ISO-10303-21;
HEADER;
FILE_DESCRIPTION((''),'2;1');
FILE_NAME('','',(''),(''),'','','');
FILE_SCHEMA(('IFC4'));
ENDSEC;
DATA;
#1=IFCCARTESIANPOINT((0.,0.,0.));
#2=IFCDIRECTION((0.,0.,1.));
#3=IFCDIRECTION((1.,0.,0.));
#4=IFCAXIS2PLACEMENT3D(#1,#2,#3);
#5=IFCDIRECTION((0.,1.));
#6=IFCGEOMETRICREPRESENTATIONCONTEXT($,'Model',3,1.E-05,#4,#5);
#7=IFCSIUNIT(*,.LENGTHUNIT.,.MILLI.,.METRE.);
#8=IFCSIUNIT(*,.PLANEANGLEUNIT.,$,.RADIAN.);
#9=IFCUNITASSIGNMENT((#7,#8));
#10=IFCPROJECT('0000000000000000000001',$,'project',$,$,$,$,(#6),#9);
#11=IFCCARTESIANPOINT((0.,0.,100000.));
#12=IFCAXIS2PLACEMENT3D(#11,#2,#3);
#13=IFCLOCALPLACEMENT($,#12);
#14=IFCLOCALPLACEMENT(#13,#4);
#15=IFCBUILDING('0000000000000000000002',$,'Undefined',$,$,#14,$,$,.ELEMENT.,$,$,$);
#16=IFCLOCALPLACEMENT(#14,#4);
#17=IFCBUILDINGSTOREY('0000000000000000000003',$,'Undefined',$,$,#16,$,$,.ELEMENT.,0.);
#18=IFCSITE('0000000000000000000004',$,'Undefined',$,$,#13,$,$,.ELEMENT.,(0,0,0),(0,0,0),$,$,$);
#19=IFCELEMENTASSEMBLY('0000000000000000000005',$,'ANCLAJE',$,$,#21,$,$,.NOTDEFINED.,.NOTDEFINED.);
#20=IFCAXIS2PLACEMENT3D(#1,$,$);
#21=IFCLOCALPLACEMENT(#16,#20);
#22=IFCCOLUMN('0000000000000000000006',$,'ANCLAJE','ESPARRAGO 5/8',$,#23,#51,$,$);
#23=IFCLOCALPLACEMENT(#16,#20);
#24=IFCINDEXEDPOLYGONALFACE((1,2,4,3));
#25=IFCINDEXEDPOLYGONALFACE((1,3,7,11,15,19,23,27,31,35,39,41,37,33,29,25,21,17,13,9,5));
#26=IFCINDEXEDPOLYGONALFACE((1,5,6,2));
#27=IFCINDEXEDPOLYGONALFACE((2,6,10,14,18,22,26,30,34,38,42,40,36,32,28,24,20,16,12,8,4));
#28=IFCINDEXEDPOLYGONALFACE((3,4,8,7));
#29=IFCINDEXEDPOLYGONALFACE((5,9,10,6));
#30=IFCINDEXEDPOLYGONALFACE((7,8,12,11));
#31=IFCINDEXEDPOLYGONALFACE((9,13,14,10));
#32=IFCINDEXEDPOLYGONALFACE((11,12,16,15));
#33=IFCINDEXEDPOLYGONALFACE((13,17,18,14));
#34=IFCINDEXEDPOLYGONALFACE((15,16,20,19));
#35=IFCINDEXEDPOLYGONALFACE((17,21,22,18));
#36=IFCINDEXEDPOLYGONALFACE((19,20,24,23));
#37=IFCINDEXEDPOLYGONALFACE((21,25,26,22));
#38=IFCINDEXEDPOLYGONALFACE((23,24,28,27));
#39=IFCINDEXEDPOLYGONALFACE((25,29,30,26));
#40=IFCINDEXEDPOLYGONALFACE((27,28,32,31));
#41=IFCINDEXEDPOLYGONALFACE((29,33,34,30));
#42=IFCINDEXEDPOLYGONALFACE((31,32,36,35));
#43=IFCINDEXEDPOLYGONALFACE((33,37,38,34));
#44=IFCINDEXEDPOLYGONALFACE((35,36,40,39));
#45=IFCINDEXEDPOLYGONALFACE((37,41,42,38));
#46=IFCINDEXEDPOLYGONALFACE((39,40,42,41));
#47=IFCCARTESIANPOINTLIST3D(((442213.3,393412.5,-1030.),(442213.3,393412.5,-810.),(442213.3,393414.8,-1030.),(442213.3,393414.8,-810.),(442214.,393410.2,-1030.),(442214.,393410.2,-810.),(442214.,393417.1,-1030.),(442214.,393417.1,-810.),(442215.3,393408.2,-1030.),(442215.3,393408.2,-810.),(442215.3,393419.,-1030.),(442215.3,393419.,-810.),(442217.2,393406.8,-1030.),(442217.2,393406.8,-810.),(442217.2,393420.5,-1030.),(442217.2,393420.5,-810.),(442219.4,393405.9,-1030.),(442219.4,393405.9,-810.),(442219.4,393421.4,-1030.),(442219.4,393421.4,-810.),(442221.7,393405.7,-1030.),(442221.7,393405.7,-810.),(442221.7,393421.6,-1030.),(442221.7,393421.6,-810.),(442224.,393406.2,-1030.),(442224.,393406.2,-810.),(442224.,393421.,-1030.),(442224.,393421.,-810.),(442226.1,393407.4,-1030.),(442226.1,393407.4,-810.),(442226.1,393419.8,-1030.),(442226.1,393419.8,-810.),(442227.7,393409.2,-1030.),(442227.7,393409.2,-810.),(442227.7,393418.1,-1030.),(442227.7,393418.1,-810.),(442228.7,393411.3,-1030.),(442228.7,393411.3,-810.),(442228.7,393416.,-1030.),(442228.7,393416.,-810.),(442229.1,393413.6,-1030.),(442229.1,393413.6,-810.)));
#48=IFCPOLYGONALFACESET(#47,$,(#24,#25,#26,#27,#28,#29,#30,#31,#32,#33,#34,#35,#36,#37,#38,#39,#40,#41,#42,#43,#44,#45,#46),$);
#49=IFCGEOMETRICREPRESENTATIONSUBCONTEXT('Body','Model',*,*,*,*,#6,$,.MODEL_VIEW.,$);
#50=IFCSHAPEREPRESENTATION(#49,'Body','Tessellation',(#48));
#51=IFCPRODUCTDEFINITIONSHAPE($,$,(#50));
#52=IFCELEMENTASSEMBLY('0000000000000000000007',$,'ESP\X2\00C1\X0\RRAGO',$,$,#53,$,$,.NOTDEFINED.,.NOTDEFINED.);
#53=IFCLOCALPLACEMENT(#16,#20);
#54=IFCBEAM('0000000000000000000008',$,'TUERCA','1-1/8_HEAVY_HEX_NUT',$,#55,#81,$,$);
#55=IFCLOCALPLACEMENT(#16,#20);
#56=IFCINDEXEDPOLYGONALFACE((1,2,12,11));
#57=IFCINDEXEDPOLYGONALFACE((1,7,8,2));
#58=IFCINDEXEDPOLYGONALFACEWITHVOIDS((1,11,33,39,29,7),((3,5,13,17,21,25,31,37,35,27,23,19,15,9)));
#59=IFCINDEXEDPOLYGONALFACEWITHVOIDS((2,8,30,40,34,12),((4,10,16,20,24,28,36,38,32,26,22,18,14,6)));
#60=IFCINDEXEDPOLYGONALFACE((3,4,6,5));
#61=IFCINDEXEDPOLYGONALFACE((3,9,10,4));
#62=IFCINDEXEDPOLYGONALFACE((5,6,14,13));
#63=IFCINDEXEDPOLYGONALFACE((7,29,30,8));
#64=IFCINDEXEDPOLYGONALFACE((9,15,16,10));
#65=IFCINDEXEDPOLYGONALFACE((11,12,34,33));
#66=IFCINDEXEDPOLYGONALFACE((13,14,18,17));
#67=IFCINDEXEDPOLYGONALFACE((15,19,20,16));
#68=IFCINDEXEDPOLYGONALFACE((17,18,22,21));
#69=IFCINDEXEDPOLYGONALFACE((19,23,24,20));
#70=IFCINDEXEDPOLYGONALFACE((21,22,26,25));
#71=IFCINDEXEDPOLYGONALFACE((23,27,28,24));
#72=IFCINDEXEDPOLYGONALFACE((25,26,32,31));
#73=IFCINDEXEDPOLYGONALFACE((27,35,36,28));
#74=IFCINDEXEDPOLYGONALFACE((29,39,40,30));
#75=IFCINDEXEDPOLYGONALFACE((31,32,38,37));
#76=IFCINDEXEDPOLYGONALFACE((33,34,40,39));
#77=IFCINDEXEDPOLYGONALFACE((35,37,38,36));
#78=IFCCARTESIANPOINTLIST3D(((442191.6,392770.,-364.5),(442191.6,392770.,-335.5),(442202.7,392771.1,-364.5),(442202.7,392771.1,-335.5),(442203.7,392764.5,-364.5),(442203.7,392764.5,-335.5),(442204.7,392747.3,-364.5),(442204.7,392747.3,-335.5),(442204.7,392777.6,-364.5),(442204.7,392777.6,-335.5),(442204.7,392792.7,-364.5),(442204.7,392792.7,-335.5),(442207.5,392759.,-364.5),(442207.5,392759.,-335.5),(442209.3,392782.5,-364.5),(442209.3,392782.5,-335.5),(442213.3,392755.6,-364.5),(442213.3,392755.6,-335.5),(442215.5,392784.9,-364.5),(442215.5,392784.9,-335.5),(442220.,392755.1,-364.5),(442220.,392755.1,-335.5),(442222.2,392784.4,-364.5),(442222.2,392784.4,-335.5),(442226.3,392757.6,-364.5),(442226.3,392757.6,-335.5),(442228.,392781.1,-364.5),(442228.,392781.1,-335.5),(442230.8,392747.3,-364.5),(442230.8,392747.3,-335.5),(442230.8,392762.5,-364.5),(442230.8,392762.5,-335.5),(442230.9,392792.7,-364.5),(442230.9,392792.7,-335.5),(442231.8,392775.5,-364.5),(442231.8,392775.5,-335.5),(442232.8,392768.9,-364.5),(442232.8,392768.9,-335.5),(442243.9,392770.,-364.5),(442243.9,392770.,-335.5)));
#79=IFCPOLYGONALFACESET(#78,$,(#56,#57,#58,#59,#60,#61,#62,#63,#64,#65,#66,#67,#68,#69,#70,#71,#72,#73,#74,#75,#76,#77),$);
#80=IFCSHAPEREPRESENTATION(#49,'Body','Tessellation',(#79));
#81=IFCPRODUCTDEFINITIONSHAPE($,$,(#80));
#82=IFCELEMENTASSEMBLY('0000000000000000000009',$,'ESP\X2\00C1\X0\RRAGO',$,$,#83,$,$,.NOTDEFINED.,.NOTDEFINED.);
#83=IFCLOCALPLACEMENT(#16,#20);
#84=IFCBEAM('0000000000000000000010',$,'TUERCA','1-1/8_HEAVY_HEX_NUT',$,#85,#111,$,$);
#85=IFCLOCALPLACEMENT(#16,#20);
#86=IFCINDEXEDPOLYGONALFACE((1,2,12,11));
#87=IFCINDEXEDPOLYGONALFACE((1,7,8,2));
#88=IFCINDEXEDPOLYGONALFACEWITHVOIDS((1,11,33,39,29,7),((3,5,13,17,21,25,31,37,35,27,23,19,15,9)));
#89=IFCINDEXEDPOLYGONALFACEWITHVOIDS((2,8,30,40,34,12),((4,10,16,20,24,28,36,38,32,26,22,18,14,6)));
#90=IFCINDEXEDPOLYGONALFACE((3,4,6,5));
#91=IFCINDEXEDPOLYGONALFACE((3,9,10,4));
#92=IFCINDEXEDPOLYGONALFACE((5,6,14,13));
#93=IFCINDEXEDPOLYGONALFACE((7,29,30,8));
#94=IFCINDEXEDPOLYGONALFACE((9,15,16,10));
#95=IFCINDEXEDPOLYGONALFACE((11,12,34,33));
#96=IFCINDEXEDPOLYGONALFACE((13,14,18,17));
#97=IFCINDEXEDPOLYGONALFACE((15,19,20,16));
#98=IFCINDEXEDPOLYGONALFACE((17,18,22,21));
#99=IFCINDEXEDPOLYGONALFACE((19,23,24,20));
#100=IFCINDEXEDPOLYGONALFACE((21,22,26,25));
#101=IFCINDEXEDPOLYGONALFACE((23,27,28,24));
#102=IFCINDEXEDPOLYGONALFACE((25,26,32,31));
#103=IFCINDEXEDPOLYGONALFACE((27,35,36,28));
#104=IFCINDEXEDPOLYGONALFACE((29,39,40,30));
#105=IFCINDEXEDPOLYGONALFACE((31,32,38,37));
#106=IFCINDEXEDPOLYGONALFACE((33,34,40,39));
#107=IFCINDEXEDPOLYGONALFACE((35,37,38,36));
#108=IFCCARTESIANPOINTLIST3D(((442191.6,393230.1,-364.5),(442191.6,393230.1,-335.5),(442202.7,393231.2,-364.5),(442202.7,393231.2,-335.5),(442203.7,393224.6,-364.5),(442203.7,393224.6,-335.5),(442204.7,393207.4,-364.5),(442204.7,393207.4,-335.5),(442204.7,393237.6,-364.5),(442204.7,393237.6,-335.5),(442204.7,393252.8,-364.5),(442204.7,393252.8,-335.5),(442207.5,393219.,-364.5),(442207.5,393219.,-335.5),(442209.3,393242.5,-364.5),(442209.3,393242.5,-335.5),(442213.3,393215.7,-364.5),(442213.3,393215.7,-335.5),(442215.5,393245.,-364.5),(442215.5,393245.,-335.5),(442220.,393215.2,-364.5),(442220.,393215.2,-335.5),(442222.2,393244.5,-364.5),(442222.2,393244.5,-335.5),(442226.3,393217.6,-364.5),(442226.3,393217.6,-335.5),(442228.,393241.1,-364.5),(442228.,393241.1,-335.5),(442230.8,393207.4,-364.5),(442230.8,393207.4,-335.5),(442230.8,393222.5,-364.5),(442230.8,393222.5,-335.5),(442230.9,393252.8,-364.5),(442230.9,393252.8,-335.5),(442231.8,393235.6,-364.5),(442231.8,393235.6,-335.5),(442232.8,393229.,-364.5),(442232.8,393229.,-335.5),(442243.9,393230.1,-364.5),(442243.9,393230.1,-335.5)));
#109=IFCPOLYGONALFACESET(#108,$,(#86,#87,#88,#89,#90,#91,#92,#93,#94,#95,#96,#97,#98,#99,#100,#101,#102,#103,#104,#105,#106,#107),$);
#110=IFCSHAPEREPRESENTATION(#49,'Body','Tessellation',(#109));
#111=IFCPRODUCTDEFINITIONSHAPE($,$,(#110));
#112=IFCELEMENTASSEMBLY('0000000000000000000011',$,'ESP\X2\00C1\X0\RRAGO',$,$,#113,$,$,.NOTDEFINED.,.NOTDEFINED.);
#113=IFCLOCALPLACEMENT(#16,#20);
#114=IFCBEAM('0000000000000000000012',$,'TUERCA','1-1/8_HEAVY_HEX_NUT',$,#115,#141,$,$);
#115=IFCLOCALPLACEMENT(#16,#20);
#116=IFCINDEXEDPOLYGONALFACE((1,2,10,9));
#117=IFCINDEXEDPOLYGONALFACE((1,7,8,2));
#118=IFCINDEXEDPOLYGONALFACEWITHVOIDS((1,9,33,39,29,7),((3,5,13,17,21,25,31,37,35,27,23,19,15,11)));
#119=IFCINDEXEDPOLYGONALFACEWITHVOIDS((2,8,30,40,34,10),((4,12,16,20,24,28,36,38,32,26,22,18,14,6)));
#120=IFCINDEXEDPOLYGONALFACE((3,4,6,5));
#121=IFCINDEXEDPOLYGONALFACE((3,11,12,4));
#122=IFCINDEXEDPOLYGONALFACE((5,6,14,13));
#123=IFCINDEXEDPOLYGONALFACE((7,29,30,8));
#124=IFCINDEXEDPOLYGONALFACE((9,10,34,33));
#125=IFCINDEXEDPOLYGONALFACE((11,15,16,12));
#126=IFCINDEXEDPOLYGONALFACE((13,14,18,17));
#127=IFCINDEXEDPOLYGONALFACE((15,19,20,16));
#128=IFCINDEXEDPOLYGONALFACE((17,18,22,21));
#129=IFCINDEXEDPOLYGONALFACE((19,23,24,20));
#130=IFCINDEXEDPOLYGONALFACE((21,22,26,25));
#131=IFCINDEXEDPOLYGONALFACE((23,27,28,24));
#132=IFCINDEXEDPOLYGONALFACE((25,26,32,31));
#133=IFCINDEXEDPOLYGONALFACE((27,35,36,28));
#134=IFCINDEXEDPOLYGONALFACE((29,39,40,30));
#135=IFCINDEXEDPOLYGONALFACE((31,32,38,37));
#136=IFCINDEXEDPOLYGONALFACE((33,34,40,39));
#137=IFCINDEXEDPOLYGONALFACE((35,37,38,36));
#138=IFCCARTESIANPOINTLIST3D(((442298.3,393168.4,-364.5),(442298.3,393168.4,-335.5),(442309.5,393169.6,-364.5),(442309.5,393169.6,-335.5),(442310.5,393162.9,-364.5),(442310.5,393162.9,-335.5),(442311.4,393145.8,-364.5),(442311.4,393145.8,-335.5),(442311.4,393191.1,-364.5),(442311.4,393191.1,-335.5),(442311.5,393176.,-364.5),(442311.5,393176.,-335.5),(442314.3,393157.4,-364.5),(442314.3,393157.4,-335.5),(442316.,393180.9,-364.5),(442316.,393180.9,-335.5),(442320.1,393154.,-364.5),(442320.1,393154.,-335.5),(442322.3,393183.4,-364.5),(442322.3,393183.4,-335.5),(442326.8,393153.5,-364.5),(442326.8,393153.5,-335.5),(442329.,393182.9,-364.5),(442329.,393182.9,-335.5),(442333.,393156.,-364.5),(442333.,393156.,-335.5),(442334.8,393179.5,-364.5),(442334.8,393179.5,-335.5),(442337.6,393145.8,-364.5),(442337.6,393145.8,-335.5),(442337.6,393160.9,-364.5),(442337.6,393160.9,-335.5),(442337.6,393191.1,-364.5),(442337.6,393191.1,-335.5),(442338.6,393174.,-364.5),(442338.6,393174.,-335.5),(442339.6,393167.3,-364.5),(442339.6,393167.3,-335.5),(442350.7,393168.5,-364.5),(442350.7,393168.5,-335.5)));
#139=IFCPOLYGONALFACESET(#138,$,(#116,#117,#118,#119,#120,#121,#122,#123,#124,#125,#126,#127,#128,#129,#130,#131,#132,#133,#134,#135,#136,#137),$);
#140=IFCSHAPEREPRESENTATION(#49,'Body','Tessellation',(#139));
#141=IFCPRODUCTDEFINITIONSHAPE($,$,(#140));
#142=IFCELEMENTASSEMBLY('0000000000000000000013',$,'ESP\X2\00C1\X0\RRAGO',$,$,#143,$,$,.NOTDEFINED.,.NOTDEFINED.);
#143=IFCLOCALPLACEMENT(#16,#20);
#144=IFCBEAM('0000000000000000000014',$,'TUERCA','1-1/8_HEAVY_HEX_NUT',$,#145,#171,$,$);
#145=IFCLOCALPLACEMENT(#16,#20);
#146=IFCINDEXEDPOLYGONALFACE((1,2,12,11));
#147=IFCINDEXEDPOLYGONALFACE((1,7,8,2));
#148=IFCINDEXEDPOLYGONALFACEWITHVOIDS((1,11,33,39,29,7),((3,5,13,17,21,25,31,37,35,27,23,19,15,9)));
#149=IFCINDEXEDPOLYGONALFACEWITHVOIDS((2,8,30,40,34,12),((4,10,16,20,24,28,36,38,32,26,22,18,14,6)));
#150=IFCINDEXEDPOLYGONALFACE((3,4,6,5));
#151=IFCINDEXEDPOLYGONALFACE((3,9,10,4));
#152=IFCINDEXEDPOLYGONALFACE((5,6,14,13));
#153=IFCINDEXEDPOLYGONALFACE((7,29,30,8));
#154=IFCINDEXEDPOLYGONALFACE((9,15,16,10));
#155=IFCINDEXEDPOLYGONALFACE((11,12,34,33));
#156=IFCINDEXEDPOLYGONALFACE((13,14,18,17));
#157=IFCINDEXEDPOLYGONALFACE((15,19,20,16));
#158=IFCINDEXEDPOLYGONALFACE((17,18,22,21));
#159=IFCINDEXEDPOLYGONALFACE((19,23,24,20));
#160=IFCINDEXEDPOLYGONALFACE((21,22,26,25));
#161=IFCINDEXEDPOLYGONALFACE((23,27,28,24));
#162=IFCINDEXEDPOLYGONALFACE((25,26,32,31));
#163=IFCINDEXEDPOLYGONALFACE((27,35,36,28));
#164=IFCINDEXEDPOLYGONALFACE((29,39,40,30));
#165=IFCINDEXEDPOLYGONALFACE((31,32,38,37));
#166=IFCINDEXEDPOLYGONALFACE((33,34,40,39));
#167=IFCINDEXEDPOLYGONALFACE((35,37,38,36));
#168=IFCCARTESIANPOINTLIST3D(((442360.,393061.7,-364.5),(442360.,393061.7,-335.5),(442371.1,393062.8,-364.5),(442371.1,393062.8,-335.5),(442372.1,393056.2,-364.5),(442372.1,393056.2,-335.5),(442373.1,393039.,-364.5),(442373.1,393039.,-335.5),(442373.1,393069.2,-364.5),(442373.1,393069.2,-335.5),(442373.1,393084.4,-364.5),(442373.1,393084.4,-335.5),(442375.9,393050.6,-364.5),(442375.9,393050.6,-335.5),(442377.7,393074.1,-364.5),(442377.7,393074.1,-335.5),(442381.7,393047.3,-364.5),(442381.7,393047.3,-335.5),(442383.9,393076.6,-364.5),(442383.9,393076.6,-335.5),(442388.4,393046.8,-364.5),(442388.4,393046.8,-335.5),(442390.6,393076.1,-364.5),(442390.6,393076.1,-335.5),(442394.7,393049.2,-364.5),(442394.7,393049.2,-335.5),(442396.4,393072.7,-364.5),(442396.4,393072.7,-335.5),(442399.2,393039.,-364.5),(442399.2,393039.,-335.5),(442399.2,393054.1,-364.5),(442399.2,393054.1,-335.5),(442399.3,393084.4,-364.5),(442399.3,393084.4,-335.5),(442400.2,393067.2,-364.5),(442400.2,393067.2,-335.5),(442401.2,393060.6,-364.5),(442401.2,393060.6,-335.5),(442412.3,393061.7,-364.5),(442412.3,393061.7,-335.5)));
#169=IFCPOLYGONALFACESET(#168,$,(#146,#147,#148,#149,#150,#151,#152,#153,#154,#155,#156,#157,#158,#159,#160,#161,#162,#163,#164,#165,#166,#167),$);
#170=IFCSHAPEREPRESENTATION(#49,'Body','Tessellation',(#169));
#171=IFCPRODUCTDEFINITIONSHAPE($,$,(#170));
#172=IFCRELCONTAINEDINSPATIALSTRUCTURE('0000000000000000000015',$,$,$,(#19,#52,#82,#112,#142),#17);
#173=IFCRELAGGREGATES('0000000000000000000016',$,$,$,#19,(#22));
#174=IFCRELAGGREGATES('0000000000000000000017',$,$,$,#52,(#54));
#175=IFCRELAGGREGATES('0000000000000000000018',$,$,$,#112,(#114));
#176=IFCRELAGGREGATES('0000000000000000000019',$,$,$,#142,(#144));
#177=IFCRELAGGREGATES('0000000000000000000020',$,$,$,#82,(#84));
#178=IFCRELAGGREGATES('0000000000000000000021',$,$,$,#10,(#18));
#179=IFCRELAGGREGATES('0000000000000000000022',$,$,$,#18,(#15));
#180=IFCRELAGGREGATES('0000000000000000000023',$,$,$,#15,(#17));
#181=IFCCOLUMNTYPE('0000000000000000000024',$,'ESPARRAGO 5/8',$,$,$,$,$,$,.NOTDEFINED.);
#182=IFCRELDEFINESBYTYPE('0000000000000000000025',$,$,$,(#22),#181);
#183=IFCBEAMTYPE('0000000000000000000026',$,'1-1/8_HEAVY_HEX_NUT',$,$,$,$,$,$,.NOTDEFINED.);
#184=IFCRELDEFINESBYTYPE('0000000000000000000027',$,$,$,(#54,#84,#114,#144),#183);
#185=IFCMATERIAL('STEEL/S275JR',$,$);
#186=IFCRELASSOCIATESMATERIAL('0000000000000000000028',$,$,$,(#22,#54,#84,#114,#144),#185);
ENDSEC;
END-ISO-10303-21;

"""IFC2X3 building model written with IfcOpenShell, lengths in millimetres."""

from ifc_helpers import new_model, si_unit, direction, frame, origin_with_axes, origin_2d_with_axis, place, context, subcontext, project, spatial, polyline, circle, outline, extrude, material, type_object, element, aggregate, save


model = new_model("IFC2X3")

# Units and contexts
model_context = context("Model", 3, precision=1e-05, world=origin_with_axes(), true_north=direction((0.0, 1.0)))
body_context = subcontext(model_context, "Body", "Model", "MODEL_VIEW")
ifc_project = project(units=[si_unit("LENGTHUNIT", "METRE", prefix="MILLI"), si_unit("PLANEANGLEUNIT", "RADIAN")], contexts=[model_context])

# Site, building, storey
site_placement = place(None, frame((0.0, 0.0, 100000.0), z_axis=(0.0, 0.0, 1.0), x_axis=(1.0, 0.0, 0.0)))
site = spatial("IfcSite", under=ifc_project, at=site_placement, Name="Undefined", CompositionType="ELEMENT", RefLatitude=(0, 0, 0), RefLongitude=(0, 0, 0))
building_placement = place(site_placement, origin_with_axes())
building = spatial("IfcBuilding", under=site, at=building_placement, Name="Undefined", CompositionType="ELEMENT")
storey_placement = place(building_placement, origin_with_axes())
storey = spatial("IfcBuildingStorey", under=building, at=storey_placement, Name="Undefined", CompositionType="ELEMENT", Elevation=0.0)

# Element assembly
ifc_material_1 = material(Name="STEEL/S275JR")
assembly_1_placement = place(storey_placement, origin_with_axes())
assembly_1 = element("IfcElementAssembly", 1, at=assembly_1_placement, inside=storey, Name="ANCLAJE", AssemblyPlace="NOTDEFINED", PredefinedType="NOTDEFINED")

# Column
column_type_1 = type_object("IfcColumnType", Name="ESPARRAGO 5/8", PredefinedType="NOTDEFINED")
column_1_placement = place(assembly_1_placement, frame((442221.1, 393413.6, -810.0), z_axis=(0.0, 0.0, -1.0), x_axis=(0.0, 1.0, 0.0)))
column_1 = element("IfcColumn", 2, at=column_1_placement, type_object=column_type_1, material=ifc_material_1, Name="ANCLAJE", Description="ESPARRAGO 5/8", context=body_context, shape_type="SweptSolid", body=[
    extrude(circle(Radius=7.9, at=origin_2d_with_axis()), frame((0.0, 0.0, 220.0), z_axis=(0.0, 0.0, -1.0), x_axis=(0.0, 1.0, 0.0)), (0.0, 0.0, 1.0), 220.0),
])
aggregate(assembly_1, [column_1])

# Element assemblies, beams
assembly_2_placement = place(storey_placement, origin_with_axes())
assembly_2 = element("IfcElementAssembly", 3, at=assembly_2_placement, inside=storey, Name="ESPÁRRAGO", AssemblyPlace="NOTDEFINED", PredefinedType="NOTDEFINED")
beam_type_1 = type_object("IfcBeamType", Name="1-1/8_HEAVY_HEX_NUT", PredefinedType="NOTDEFINED")
beam_1_placement = place(assembly_2_placement, frame((442217.8, 392770.0, -335.5), z_axis=(0.866025, -0.5, 0.0), x_axis=(0.0, 0.0, -1.0)))
beam_1 = element("IfcBeam", 4, at=beam_1_placement, type_object=beam_type_1, material=ifc_material_1, Name="TUERCA", Description="1-1/8_HEAVY_HEX_NUT", context=body_context, shape_type="SweptSolid", body=[
    extrude(outline(polyline([(-13.1, -22.7), (-26.2, 0.0), (-13.1, 22.7), (13.1, 22.7), (26.2, 0.0), (13.1, -22.7), (-13.1, -22.7)]), holes=[polyline([(6.5, 13.6), (0.0, 15.1), (-6.5, 13.6), (-11.8, 9.4), (-14.7, 3.4), (-14.7, -3.4), (-11.8, -9.4), (-6.5, -13.6), (0.0, -15.1), (6.5, -13.6), (11.8, -9.4), (14.7, -3.4), (14.7, 3.4), (11.8, 9.4), (6.5, 13.6)])]), frame((29.0, 0.0, 0.0), z_axis=(-1.0, 0.0, 0.0), x_axis=(0.0, -1.0, 0.0)), (0.0, 0.0, 1.0), 29.0),
])
assembly_3_placement = place(storey_placement, origin_with_axes())
assembly_3 = element("IfcElementAssembly", 5, at=assembly_3_placement, inside=storey, Name="ESPÁRRAGO", AssemblyPlace="NOTDEFINED", PredefinedType="NOTDEFINED")
beam_2_placement = place(assembly_3_placement, frame((442217.8, 393230.1, -335.5), z_axis=(0.866025, -0.5, 0.0), x_axis=(0.0, 0.0, -1.0)))
beam_2 = element("IfcBeam", 6, at=beam_2_placement, type_object=beam_type_1, material=ifc_material_1, Name="TUERCA", Description="1-1/8_HEAVY_HEX_NUT", context=body_context, shape_type="SweptSolid", body=[
    extrude(outline(polyline([(-13.1, -22.7), (-26.2, 0.0), (-13.1, 22.7), (13.1, 22.7), (26.2, 0.0), (13.1, -22.7), (-13.1, -22.7)]), holes=[polyline([(6.5, 13.6), (0.0, 15.1), (-6.5, 13.6), (-11.8, 9.4), (-14.7, 3.4), (-14.7, -3.4), (-11.8, -9.4), (-6.5, -13.6), (0.0, -15.1), (6.5, -13.6), (11.8, -9.4), (14.7, -3.4), (14.7, 3.4), (11.8, 9.4), (6.5, 13.6)])]), frame((29.0, 0.0, 0.0), z_axis=(-1.0, 0.0, 0.0), x_axis=(0.0, -1.0, 0.0)), (0.0, 0.0, 1.0), 29.0),
])
assembly_4_placement = place(storey_placement, origin_with_axes())
assembly_4 = element("IfcElementAssembly", 7, at=assembly_4_placement, inside=storey, Name="ESPÁRRAGO", AssemblyPlace="NOTDEFINED", PredefinedType="NOTDEFINED")
beam_3_placement = place(assembly_4_placement, frame((442324.5, 393168.4, -335.5), z_axis=(0.866025, -0.5, 0.0), x_axis=(0.0, 0.0, -1.0)))
beam_3 = element("IfcBeam", 8, at=beam_3_placement, type_object=beam_type_1, material=ifc_material_1, Name="TUERCA", Description="1-1/8_HEAVY_HEX_NUT", context=body_context, shape_type="SweptSolid", body=[
    extrude(outline(polyline([(-13.1, -22.7), (-26.2, 0.0), (-13.1, 22.7), (13.1, 22.7), (26.2, 0.0), (13.1, -22.7), (-13.1, -22.7)]), holes=[polyline([(6.5, 13.6), (0.0, 15.1), (-6.5, 13.6), (-11.8, 9.4), (-14.7, 3.4), (-14.7, -3.4), (-11.8, -9.4), (-6.5, -13.6), (0.0, -15.1), (6.5, -13.6), (11.8, -9.4), (14.7, -3.4), (14.7, 3.4), (11.8, 9.4), (6.5, 13.6)])]), frame((29.0, 0.0, 0.0), z_axis=(-1.0, 0.0, 0.0), x_axis=(0.0, -1.0, 0.0)), (0.0, 0.0, 1.0), 29.0),
])
assembly_5_placement = place(storey_placement, origin_with_axes())
assembly_5 = element("IfcElementAssembly", 9, at=assembly_5_placement, inside=storey, Name="ESPÁRRAGO", AssemblyPlace="NOTDEFINED", PredefinedType="NOTDEFINED")
beam_4_placement = place(assembly_5_placement, frame((442386.2, 393061.7, -335.5), z_axis=(0.866025, -0.5, 0.0), x_axis=(0.0, 0.0, -1.0)))
beam_4 = element("IfcBeam", 10, at=beam_4_placement, type_object=beam_type_1, material=ifc_material_1, Name="TUERCA", Description="1-1/8_HEAVY_HEX_NUT", context=body_context, shape_type="SweptSolid", body=[
    extrude(outline(polyline([(-13.1, -22.7), (-26.2, 0.0), (-13.1, 22.7), (13.1, 22.7), (26.2, 0.0), (13.1, -22.7), (-13.1, -22.7)]), holes=[polyline([(6.5, 13.6), (0.0, 15.1), (-6.5, 13.6), (-11.8, 9.4), (-14.7, 3.4), (-14.7, -3.4), (-11.8, -9.4), (-6.5, -13.6), (0.0, -15.1), (6.5, -13.6), (11.8, -9.4), (14.7, -3.4), (14.7, 3.4), (11.8, 9.4), (6.5, 13.6)])]), frame((29.0, 0.0, 0.0), z_axis=(-1.0, 0.0, 0.0), x_axis=(0.0, -1.0, 0.0)), (0.0, 0.0, 1.0), 29.0),
])

aggregate(assembly_2, [beam_1])
aggregate(assembly_4, [beam_3])
aggregate(assembly_5, [beam_4])
aggregate(assembly_3, [beam_2])

save(model, "model.ifc")
